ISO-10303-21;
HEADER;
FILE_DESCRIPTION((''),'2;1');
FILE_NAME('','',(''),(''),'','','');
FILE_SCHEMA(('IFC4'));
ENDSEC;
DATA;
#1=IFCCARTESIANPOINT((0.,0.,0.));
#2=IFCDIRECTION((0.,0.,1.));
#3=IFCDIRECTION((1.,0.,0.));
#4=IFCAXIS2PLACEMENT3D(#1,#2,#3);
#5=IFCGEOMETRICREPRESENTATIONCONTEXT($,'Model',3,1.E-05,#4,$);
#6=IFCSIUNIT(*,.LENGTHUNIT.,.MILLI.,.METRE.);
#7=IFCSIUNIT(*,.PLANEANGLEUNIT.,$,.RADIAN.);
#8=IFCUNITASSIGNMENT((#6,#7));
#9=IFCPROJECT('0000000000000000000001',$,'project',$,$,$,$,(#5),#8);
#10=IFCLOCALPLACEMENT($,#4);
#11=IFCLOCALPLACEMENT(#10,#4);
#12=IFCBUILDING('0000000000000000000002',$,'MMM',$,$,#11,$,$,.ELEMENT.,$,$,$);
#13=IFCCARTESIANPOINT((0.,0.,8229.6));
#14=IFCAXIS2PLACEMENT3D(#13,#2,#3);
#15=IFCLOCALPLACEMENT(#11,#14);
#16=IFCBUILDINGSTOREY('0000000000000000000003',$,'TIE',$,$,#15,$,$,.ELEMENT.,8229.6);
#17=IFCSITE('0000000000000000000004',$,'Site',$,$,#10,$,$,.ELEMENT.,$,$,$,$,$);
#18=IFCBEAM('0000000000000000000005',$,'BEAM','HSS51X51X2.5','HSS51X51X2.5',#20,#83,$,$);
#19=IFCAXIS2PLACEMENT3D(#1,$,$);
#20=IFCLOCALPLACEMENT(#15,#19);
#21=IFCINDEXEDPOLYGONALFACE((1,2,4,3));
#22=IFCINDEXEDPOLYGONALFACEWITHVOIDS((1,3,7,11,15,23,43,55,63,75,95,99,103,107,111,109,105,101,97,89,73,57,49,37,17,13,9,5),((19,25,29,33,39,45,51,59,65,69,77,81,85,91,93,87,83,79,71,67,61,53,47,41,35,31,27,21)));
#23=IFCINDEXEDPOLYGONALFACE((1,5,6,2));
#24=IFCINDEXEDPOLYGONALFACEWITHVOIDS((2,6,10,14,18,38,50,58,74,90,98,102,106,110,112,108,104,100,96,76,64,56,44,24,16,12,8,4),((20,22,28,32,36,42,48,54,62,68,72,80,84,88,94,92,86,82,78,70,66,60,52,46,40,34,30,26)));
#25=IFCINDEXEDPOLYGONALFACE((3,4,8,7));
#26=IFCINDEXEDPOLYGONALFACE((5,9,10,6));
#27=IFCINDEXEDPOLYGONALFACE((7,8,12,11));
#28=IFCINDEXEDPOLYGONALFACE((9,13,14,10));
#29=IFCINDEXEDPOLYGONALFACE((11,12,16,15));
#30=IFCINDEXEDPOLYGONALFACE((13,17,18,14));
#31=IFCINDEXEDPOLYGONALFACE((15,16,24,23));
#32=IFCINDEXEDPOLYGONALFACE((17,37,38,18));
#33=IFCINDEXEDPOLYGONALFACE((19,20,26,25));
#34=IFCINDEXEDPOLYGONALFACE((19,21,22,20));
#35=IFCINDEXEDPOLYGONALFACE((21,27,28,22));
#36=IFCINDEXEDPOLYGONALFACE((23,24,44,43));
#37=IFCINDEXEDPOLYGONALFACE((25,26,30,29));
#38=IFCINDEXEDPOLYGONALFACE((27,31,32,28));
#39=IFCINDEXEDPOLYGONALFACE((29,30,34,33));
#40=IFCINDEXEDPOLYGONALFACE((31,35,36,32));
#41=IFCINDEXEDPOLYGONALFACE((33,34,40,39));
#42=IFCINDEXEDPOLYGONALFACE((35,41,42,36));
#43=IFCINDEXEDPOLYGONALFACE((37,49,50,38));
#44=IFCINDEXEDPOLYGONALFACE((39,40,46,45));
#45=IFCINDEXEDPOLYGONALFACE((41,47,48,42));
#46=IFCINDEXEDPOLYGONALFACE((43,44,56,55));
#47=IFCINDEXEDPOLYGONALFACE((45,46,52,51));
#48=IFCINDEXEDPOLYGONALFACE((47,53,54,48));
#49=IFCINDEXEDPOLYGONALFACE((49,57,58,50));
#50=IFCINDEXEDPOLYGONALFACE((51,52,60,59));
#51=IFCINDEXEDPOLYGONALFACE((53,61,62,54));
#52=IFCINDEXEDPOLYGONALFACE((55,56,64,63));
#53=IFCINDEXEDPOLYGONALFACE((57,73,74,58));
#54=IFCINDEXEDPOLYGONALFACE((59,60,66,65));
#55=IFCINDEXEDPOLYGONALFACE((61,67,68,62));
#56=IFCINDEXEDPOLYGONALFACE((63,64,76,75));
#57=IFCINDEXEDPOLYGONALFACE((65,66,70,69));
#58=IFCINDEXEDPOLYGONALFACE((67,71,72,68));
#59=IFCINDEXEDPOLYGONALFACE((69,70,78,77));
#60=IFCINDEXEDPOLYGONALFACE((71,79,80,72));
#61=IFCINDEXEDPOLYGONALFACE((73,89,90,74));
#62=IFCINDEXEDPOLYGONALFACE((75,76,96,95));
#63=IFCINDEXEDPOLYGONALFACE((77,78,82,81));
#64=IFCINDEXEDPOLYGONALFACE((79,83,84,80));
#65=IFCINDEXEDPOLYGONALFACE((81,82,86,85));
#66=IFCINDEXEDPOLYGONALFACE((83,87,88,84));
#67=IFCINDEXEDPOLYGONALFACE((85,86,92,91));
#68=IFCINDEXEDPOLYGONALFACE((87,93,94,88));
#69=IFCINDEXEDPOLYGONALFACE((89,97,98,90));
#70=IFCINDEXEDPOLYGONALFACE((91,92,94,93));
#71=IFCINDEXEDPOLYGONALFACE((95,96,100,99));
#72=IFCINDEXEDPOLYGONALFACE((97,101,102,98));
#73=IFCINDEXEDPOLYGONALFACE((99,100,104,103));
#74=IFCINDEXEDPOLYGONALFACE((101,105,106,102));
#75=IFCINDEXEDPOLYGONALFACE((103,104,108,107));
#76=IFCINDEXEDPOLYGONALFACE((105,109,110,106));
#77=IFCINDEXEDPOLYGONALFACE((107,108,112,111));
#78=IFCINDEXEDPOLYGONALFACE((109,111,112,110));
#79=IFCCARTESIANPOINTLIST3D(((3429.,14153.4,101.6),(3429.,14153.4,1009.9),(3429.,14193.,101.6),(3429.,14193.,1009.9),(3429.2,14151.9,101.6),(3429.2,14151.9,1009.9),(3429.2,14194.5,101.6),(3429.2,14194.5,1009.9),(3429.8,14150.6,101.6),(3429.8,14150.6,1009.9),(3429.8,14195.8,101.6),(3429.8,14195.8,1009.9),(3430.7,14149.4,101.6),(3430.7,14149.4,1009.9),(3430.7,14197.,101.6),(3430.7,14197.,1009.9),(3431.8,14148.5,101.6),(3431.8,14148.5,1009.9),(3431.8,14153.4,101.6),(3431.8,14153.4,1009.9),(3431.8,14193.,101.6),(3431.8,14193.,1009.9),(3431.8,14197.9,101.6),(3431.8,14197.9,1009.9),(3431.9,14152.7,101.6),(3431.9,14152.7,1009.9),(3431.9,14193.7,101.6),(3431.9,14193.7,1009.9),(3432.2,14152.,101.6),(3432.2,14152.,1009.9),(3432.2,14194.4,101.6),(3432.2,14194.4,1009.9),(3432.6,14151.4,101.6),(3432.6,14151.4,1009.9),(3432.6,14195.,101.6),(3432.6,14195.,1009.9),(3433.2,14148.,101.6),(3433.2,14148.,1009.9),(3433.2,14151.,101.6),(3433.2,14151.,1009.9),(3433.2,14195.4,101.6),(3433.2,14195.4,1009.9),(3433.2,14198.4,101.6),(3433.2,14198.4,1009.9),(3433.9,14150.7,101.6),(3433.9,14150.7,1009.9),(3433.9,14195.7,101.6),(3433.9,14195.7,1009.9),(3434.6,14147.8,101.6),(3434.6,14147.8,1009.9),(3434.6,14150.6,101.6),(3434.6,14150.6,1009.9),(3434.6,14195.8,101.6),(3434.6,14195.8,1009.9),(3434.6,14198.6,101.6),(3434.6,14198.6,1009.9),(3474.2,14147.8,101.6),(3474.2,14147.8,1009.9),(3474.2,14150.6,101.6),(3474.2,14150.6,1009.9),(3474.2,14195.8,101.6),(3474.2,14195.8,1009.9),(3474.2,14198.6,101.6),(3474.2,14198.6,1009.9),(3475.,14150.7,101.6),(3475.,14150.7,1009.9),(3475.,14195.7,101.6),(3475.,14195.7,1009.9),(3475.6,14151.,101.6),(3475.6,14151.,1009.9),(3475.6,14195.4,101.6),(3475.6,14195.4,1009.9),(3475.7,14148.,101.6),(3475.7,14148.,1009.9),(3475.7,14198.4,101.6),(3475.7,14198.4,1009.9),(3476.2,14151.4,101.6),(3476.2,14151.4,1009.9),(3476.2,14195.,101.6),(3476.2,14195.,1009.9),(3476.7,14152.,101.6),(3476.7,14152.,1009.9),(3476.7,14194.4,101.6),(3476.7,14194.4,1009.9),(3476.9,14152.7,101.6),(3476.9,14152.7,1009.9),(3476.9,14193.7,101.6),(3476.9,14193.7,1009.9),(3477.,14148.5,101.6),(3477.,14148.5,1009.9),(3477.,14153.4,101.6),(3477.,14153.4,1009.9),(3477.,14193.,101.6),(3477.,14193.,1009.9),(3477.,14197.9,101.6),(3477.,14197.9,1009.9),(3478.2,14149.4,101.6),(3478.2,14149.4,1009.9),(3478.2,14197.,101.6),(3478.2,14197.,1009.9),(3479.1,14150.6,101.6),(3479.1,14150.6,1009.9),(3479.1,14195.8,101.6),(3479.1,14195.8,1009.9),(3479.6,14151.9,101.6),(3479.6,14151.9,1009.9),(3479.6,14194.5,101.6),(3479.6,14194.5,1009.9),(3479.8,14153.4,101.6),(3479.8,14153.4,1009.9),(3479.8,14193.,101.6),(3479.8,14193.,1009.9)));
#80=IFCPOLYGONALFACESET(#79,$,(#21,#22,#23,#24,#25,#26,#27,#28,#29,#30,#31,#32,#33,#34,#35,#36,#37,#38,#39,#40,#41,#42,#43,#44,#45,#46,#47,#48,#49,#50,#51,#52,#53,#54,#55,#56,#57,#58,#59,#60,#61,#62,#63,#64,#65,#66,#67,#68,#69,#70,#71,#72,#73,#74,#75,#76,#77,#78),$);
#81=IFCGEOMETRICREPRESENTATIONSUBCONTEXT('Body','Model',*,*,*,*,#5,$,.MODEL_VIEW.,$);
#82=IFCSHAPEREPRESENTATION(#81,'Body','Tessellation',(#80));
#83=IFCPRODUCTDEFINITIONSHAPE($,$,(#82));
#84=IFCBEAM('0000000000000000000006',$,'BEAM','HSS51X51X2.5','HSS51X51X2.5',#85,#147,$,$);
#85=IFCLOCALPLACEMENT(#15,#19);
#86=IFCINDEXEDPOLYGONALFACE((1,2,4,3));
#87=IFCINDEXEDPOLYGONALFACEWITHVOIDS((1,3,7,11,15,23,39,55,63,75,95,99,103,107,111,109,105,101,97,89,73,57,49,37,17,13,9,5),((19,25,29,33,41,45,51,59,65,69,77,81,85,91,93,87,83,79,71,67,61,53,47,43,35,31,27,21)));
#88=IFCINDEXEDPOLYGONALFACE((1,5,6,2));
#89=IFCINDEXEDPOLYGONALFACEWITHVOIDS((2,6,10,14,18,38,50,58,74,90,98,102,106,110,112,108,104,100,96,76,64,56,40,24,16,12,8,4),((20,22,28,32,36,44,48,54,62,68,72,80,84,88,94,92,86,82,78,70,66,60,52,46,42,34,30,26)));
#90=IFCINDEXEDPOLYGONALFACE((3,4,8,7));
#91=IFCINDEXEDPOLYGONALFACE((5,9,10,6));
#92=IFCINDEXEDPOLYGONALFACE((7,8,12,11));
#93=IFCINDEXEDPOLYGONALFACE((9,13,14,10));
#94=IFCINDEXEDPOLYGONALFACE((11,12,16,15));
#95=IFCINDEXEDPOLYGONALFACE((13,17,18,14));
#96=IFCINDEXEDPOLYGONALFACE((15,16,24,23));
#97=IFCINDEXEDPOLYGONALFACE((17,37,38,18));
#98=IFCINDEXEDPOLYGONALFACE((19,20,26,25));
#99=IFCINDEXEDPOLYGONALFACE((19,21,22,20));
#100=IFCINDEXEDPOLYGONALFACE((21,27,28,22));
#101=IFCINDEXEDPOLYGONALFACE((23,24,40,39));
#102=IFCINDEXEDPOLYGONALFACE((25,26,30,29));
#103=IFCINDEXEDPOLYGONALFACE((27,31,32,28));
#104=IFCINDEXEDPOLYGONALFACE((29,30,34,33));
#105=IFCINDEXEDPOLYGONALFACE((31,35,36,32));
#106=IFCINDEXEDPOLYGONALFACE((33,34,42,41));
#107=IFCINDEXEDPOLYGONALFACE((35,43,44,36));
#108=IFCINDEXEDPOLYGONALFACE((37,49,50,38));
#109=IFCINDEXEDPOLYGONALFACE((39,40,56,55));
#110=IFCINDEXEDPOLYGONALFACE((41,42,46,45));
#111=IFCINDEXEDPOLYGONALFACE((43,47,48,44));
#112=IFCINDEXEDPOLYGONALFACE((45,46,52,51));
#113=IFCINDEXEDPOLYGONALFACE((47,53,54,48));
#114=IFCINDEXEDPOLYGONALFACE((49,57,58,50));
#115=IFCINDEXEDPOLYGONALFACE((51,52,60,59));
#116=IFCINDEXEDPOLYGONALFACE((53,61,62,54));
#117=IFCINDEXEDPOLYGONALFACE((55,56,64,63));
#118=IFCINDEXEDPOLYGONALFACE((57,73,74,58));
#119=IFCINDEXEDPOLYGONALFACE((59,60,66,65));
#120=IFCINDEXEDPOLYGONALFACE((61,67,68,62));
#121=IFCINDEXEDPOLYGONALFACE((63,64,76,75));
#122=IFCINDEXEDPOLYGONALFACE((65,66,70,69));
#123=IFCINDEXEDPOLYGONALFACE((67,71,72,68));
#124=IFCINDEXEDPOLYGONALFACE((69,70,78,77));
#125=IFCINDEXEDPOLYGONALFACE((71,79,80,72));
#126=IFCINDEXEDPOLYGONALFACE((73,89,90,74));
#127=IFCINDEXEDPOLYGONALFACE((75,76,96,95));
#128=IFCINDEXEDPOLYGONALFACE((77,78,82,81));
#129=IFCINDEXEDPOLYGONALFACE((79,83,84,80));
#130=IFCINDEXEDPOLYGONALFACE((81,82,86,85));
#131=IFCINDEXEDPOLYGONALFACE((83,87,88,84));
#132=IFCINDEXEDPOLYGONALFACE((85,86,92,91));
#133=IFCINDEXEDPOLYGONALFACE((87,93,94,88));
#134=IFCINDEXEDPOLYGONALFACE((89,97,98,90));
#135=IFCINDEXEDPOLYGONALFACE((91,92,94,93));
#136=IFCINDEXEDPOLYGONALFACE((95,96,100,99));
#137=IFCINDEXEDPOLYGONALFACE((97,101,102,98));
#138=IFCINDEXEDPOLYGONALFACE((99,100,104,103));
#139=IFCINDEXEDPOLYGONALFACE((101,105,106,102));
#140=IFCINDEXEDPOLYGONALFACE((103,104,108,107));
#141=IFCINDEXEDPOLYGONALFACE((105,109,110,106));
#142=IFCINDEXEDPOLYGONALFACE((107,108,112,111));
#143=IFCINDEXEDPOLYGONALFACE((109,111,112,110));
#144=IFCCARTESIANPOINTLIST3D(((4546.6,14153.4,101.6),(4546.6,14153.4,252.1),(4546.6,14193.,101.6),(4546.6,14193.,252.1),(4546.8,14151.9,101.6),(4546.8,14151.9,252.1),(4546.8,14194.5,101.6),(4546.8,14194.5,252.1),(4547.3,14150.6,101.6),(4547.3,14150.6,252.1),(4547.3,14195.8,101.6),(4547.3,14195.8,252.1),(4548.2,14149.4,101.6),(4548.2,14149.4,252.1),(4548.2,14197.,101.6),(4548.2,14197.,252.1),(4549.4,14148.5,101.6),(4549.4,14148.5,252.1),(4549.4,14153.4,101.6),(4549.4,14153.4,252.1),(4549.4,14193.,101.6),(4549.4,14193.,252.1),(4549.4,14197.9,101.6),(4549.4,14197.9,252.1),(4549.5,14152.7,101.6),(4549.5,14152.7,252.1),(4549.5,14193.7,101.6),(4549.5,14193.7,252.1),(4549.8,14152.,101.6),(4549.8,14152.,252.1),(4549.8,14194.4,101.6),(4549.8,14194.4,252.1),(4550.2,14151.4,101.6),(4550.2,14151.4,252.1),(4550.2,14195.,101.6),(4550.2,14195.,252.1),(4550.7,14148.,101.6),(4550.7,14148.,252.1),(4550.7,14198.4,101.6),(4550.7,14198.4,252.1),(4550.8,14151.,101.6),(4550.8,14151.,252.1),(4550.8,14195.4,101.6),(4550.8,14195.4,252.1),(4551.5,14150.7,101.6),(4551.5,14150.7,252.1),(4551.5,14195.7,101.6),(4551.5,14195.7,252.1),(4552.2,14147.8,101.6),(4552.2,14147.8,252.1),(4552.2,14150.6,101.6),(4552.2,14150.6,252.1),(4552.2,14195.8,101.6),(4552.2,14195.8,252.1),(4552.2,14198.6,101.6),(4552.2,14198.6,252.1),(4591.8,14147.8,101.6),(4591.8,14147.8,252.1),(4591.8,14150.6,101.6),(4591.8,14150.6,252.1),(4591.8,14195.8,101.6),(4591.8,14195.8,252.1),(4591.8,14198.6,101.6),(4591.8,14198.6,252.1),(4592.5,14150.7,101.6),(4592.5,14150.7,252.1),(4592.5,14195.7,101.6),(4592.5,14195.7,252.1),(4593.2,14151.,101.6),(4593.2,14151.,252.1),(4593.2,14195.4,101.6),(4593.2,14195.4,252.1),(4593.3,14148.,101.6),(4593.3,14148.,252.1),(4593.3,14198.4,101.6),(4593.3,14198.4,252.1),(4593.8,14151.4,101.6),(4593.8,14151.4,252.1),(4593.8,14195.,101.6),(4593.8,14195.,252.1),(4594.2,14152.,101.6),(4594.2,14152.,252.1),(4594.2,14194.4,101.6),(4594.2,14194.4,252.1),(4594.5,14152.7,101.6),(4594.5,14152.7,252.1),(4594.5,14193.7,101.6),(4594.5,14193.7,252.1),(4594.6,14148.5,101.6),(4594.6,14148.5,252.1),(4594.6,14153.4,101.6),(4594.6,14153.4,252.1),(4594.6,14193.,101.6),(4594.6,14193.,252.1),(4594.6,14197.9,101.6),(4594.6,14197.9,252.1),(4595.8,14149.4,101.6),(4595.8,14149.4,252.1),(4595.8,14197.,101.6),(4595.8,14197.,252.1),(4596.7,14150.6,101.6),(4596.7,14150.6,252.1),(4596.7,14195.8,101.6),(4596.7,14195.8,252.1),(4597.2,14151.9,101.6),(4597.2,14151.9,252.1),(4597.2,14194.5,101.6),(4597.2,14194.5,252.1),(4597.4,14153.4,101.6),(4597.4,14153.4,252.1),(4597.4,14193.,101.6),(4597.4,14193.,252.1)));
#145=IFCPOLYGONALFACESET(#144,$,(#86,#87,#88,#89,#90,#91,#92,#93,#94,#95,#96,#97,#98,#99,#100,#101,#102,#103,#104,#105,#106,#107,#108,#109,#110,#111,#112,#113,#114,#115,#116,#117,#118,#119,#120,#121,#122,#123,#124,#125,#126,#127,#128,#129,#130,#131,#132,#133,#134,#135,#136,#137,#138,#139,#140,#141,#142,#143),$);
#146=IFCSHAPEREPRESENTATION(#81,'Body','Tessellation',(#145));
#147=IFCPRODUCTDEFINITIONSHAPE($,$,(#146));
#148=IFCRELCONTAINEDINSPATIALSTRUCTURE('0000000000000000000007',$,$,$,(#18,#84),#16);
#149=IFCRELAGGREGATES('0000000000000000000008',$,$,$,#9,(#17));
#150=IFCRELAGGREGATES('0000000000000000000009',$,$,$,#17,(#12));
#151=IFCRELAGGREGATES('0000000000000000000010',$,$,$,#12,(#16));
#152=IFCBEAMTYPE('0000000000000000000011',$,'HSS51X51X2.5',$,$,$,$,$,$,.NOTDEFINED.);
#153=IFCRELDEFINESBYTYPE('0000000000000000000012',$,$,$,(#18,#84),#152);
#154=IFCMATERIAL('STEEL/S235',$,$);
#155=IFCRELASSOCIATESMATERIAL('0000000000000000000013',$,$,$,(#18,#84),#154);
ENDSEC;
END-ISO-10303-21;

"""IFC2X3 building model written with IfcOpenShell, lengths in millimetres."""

from ifc_helpers import new_model, si_unit, frame, origin_with_axes, origin_2d_with_axis, place, context, subcontext, project, spatial, hollow_rectangle, extrude, material, type_object, element, save


model = new_model("IFC2X3")

# Units and contexts
model_context = context("Model", 3, precision=1e-05, world=origin_with_axes())
body_context = subcontext(model_context, "Body", "Model", "MODEL_VIEW")
ifc_project = project(units=[si_unit("LENGTHUNIT", "METRE", prefix="MILLI"), si_unit("PLANEANGLEUNIT", "RADIAN")], contexts=[model_context])

# Site, building, storey
site_placement = place(None, origin_with_axes())
site = spatial("IfcSite", under=ifc_project, at=site_placement, Name="Site", CompositionType="ELEMENT")
building_placement = place(site_placement, origin_with_axes())
building = spatial("IfcBuilding", under=site, at=building_placement, Name="MMM", CompositionType="ELEMENT")
storey_placement = place(building_placement, frame((0.0, 0.0, 8229.6), z_axis=(0.0, 0.0, 1.0), x_axis=(1.0, 0.0, 0.0)))
storey = spatial("IfcBuildingStorey", under=building, at=storey_placement, Name="TIE", CompositionType="ELEMENT", Elevation=8229.6)

# Beams
ifc_material = material(Name="STEEL/S235")
beam_type_1 = type_object("IfcBeamType", Name="HSS51X51X2.5", PredefinedType="NOTDEFINED")
beam_1_placement = place(storey_placement, frame((3454.4, 14173.2, 1009.9), z_axis=(-1.0, 0.0, 0.0), x_axis=(0.0, 0.0, -1.0)))
element("IfcBeam", 1, at=beam_1_placement, inside=storey, type_object=beam_type_1, material=ifc_material, Name="BEAM", Description="HSS51X51X2.5", ObjectType="HSS51X51X2.5", context=body_context, shape_type="SweptSolid", body=[
    extrude(hollow_rectangle(XDim=50.8, YDim=50.8, WallThickness=2.8, InnerFilletRadius=2.8, OuterFilletRadius=5.6, at=origin_2d_with_axis()), frame((908.3, 0.0, 0.0), z_axis=(-1.0, 0.0, 0.0), x_axis=(0.0, -1.0, 0.0)), (0.0, 0.0, 1.0), 908.3),
])
beam_2_placement = place(storey_placement, frame((4572.0, 14173.2, 252.1), z_axis=(-1.0, 0.0, 0.0), x_axis=(0.0, 0.0, -1.0)))
element("IfcBeam", 2, at=beam_2_placement, inside=storey, type_object=beam_type_1, material=ifc_material, Name="BEAM", Description="HSS51X51X2.5", ObjectType="HSS51X51X2.5", context=body_context, shape_type="SweptSolid", body=[
    extrude(hollow_rectangle(XDim=50.8, YDim=50.8, WallThickness=2.8, InnerFilletRadius=2.8, OuterFilletRadius=5.6, at=origin_2d_with_axis()), frame((150.5, 0.0, 0.0), z_axis=(-1.0, 0.0, 0.0), x_axis=(0.0, -1.0, 0.0)), (0.0, 0.0, 1.0), 150.5),
])

save(model, "model.ifc")
